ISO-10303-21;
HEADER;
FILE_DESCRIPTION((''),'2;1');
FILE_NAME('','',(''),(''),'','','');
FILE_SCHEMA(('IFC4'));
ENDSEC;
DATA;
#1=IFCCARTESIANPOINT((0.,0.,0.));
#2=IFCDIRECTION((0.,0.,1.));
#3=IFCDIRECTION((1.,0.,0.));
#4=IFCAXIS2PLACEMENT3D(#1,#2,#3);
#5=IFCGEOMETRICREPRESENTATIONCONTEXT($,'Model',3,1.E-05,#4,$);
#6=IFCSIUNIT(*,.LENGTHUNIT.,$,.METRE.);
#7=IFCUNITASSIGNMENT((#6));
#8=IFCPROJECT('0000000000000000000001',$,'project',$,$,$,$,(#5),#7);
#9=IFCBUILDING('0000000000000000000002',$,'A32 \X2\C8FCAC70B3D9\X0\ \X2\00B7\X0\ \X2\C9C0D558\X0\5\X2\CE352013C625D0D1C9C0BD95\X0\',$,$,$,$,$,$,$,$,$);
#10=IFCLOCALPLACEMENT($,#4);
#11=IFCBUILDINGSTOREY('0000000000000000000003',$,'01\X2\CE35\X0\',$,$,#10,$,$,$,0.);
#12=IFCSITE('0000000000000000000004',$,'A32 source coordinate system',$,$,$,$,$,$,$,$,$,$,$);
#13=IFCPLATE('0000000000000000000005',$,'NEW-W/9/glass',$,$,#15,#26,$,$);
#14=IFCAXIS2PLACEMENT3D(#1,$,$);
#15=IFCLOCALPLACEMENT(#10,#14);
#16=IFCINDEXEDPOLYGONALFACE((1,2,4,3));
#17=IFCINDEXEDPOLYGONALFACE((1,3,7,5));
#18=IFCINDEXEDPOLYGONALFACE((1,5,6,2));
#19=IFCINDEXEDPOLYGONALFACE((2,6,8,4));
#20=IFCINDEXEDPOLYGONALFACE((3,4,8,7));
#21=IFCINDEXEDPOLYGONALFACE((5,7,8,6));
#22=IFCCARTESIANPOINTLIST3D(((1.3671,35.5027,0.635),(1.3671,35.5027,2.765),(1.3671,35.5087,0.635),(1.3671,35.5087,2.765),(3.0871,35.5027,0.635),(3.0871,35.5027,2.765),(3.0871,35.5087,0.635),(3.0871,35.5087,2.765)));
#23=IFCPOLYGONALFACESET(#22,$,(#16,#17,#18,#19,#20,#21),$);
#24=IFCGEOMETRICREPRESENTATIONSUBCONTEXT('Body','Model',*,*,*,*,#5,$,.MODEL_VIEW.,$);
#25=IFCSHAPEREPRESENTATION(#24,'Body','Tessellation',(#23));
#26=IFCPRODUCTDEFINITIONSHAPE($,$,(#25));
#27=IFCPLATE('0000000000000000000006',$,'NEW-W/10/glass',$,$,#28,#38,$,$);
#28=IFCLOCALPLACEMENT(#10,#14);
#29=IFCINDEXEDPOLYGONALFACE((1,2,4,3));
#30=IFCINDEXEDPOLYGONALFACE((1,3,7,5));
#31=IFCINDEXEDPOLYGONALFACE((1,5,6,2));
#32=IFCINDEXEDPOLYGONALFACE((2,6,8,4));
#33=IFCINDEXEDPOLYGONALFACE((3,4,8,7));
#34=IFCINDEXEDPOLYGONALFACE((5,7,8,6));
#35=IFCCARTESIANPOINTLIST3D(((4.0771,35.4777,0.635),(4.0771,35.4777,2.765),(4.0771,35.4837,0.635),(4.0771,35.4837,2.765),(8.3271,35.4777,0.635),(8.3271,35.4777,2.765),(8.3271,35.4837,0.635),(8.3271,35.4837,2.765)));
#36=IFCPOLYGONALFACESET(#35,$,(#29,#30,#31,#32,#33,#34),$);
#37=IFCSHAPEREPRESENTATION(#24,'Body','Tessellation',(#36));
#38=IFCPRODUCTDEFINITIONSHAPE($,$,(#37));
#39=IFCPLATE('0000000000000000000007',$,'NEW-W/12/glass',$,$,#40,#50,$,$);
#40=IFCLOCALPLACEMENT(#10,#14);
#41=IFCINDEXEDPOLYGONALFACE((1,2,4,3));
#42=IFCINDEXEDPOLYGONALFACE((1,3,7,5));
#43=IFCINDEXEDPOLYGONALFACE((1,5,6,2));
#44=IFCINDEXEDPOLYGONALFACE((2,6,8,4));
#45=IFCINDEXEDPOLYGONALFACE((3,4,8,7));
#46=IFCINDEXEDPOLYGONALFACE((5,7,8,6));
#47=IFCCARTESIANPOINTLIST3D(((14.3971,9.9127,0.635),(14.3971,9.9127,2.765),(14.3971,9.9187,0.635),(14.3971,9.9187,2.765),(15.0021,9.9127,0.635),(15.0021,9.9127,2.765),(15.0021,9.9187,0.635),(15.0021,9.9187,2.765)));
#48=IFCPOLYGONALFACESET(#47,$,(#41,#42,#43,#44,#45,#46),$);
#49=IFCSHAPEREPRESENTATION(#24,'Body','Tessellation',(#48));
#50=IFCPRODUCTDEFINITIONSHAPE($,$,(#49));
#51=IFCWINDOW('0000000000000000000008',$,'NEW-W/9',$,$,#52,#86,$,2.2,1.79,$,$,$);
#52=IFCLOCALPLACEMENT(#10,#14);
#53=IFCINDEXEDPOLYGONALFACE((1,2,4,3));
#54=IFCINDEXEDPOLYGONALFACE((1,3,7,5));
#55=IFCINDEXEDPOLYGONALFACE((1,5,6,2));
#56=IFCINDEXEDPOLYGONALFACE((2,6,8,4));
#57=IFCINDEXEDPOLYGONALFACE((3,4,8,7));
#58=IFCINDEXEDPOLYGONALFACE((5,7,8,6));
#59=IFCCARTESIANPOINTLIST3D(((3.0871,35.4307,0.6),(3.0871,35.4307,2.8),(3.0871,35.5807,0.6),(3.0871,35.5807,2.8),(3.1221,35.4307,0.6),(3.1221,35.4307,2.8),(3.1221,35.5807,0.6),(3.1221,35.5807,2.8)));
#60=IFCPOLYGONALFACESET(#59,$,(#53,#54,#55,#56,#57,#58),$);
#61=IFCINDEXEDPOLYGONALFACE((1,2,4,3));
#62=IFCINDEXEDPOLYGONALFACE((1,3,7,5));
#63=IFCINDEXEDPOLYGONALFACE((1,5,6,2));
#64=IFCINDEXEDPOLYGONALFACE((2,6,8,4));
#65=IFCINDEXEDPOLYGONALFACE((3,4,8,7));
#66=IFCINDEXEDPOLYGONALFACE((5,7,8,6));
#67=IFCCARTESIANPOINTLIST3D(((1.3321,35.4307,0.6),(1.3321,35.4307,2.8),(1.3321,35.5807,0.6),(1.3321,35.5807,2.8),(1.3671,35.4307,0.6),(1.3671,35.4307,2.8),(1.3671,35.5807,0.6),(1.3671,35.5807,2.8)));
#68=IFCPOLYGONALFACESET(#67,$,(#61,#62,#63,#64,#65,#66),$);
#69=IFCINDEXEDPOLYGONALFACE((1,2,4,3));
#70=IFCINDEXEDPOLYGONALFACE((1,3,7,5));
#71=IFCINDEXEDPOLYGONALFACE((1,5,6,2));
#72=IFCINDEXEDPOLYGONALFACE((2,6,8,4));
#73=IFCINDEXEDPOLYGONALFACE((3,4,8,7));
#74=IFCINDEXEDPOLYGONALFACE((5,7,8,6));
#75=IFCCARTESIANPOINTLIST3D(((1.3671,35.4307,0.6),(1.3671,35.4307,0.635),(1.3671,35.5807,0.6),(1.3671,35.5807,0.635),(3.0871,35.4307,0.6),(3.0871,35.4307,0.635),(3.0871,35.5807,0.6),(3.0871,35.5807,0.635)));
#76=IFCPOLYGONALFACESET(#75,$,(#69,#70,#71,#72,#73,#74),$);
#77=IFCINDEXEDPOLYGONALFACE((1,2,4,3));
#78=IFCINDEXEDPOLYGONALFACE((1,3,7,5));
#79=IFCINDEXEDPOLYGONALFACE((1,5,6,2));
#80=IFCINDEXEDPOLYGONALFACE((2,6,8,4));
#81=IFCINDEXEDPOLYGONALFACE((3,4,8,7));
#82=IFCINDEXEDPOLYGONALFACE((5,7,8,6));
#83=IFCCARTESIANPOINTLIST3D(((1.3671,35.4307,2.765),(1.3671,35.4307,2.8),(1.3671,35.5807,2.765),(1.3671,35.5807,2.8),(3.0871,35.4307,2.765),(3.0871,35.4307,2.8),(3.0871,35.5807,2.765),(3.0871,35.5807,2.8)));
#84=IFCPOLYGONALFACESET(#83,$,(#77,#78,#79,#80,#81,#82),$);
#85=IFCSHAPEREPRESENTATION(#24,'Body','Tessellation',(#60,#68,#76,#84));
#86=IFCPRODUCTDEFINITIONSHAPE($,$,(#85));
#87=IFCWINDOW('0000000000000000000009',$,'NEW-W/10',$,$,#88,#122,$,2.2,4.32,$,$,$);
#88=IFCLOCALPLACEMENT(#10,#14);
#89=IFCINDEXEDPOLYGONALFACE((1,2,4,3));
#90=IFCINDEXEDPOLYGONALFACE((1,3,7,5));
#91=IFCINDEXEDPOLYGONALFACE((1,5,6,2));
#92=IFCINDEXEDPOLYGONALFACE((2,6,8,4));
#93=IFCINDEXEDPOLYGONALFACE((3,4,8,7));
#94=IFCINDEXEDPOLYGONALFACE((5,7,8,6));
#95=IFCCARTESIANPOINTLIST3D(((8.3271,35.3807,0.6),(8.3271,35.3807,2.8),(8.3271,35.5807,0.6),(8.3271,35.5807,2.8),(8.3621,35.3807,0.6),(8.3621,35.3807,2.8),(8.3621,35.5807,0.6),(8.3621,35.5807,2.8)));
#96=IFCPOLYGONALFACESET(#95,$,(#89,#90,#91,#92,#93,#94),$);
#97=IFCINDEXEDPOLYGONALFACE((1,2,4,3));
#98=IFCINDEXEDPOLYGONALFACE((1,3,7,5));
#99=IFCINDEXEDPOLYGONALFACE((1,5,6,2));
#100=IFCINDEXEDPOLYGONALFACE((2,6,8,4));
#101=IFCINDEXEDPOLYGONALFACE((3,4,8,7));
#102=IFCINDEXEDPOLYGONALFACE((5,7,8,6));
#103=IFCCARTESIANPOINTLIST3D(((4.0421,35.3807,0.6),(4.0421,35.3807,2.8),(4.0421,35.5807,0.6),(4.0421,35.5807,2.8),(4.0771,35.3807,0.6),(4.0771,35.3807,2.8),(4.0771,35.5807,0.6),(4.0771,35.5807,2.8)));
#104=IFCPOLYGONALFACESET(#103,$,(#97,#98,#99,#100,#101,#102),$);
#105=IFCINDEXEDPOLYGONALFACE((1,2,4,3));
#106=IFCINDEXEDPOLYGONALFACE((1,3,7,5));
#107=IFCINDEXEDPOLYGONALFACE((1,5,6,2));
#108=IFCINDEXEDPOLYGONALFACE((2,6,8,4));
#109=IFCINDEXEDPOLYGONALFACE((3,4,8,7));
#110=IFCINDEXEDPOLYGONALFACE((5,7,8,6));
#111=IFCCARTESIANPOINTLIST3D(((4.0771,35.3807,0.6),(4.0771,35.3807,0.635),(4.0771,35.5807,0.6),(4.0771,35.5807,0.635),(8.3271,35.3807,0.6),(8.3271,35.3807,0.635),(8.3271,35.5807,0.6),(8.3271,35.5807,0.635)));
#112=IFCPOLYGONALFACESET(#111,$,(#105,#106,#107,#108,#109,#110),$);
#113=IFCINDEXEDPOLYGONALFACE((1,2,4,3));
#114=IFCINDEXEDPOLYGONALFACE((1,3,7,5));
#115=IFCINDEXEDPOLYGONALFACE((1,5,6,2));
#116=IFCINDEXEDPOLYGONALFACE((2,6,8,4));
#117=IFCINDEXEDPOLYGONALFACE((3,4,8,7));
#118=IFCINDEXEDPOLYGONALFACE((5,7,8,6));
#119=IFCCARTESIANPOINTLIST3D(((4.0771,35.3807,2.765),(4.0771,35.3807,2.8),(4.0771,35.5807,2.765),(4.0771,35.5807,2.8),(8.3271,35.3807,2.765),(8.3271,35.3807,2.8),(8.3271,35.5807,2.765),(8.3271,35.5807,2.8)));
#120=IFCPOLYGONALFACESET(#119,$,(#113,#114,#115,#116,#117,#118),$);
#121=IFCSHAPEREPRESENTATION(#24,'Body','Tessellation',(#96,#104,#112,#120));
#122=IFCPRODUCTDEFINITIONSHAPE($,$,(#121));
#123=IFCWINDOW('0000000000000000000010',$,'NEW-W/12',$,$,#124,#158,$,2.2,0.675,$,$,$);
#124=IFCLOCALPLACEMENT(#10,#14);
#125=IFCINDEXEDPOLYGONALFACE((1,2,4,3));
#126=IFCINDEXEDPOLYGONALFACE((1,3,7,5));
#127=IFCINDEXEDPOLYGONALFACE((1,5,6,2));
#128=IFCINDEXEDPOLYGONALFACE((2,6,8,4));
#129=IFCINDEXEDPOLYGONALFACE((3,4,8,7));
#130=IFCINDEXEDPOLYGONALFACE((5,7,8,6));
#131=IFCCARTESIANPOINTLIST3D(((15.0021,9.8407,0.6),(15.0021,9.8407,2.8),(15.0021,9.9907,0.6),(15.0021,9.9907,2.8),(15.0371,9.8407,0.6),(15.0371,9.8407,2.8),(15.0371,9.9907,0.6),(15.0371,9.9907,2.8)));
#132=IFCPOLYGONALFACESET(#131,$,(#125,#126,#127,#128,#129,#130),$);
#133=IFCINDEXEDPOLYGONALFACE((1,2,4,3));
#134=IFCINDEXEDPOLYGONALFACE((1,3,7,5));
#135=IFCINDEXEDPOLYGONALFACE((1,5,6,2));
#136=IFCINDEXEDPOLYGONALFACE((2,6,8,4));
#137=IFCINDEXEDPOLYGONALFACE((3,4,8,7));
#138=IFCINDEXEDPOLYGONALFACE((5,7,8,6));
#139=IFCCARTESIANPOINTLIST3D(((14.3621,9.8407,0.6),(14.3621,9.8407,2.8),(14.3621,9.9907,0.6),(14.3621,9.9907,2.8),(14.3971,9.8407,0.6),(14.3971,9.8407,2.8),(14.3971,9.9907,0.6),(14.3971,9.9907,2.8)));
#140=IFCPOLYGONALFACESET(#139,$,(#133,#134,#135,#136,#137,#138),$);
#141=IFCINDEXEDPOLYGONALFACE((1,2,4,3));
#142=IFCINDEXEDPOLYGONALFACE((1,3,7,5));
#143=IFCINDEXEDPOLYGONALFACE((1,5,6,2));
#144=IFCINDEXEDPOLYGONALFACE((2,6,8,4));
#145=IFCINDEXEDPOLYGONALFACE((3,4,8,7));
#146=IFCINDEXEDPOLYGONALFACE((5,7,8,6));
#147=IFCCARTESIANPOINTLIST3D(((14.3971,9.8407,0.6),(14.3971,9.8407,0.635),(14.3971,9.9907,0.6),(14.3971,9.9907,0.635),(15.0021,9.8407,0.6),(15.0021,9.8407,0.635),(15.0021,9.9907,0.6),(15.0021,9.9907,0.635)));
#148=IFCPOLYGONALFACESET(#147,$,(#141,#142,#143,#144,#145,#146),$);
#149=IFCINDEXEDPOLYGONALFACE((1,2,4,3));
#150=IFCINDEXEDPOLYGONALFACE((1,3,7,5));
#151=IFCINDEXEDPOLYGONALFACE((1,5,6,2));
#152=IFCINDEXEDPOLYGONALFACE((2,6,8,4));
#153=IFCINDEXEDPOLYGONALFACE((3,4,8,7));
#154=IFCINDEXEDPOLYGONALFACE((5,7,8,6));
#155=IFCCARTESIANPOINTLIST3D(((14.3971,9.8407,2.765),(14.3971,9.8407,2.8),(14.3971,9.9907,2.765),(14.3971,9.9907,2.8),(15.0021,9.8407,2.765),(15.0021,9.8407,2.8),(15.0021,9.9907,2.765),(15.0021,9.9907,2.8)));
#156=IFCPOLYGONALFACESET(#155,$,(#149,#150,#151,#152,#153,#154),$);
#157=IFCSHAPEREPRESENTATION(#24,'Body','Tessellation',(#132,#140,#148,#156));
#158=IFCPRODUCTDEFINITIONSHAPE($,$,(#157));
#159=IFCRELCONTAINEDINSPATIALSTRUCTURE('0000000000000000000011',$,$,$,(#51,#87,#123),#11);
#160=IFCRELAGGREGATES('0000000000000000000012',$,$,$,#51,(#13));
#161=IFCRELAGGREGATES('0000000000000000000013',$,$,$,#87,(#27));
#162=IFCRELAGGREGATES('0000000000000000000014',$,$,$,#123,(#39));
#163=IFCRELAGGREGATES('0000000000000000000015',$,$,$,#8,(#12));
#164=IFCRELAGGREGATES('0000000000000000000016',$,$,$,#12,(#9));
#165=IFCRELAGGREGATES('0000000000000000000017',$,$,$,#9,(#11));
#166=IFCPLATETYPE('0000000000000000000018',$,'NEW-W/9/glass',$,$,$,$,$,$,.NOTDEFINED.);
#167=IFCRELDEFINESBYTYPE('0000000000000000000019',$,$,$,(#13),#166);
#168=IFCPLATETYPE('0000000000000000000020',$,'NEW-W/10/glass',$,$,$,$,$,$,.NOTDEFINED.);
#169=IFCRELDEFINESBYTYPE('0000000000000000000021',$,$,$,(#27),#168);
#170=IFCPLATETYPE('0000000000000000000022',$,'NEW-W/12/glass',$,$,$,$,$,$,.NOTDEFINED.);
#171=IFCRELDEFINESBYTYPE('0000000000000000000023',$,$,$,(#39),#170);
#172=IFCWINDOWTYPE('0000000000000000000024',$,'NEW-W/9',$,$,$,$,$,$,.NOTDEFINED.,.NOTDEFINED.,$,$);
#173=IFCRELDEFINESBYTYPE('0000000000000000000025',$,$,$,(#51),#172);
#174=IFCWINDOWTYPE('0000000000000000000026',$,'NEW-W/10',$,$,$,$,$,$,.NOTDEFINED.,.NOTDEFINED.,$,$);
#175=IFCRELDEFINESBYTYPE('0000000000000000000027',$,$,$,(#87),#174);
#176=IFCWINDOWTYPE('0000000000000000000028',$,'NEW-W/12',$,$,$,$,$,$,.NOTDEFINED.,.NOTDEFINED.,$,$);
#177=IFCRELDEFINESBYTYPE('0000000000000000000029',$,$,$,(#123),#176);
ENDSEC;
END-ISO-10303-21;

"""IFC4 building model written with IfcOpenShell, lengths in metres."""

from ifc_helpers import new_model, si_unit, frame, origin, origin_with_axes, place, context, subcontext, project, spatial, polyline, outline, extrude, source, transform, mapped, type_object, type_shapes, element, aggregate, save


model = new_model("IFC4")

# Units and contexts
model_context = context("Model", 3, precision=1e-05, world=origin_with_axes())
body_context = subcontext(model_context, "Body", "Model", "MODEL_VIEW")
ifc_project = project(units=[si_unit("LENGTHUNIT", "METRE")], contexts=[model_context])

# Plates
storey_placement = place(None, origin_with_axes())
plate_type_1 = type_object("IfcPlateType", Name="NEW-W/9/glass", PredefinedType="NOTDEFINED")
shared_shape_1 = source(origin(), body_context, "Body", "SweptSolid", [
    extrude(outline(polyline([(3.0871, 35.5027), (1.3671, 35.5027), (1.3671, 35.5087), (3.0871, 35.5087), (3.0871, 35.5027)])), frame((0.0, 0.0, 0.635)), (0.0, 0.0, 1.0), 2.13),
])
type_shapes(plate_type_1, [shared_shape_1])
window_1_placement = place(storey_placement, origin_with_axes())
plate_1_placement = place(window_1_placement, origin_with_axes())
plate_1 = element("IfcPlate", 1, at=plate_1_placement, type_object=plate_type_1, Name="NEW-W/9/glass", context=body_context, shape_type="MappedRepresentation", body=[
    mapped(shared_shape_1, transform((0.0, 0.0, 0.0), scale=1.0)),
])
plate_type_2 = type_object("IfcPlateType", Name="NEW-W/10/glass", PredefinedType="NOTDEFINED")
shared_shape_2 = source(origin(), body_context, "Body", "SweptSolid", [
    extrude(outline(polyline([(8.3271, 35.4777), (4.0771, 35.4777), (4.0771, 35.4837), (8.3271, 35.4837), (8.3271, 35.4777)])), frame((0.0, 0.0, 0.635)), (0.0, 0.0, 1.0), 2.13),
])
type_shapes(plate_type_2, [shared_shape_2])
window_2_placement = place(storey_placement, origin_with_axes())
plate_2_placement = place(window_2_placement, origin_with_axes())
plate_2 = element("IfcPlate", 2, at=plate_2_placement, type_object=plate_type_2, Name="NEW-W/10/glass", context=body_context, shape_type="MappedRepresentation", body=[
    mapped(shared_shape_2, transform((0.0, 0.0, 0.0), scale=1.0)),
])
plate_type_3 = type_object("IfcPlateType", Name="NEW-W/12/glass", PredefinedType="NOTDEFINED")
shared_shape_3 = source(origin(), body_context, "Body", "SweptSolid", [
    extrude(outline(polyline([(15.0021, 9.9127), (14.3971, 9.9127), (14.3971, 9.9187), (15.0021, 9.9187), (15.0021, 9.9127)])), frame((0.0, 0.0, 0.635)), (0.0, 0.0, 1.0), 2.13),
])
type_shapes(plate_type_3, [shared_shape_3])
window_3_placement = place(storey_placement, origin_with_axes())
plate_3_placement = place(window_3_placement, origin_with_axes())
plate_3 = element("IfcPlate", 3, at=plate_3_placement, type_object=plate_type_3, Name="NEW-W/12/glass", context=body_context, shape_type="MappedRepresentation", body=[
    mapped(shared_shape_3, transform((0.0, 0.0, 0.0), scale=1.0)),
])

# Site, building, storey
site = spatial("IfcSite", under=ifc_project, Name="A32 source coordinate system")
building = spatial("IfcBuilding", under=site, Name="A32 주거동 · 지하5층–옥탑지붕")
storey = spatial("IfcBuildingStorey", under=building, at=storey_placement, Name="01층", Elevation=0.0)

# Windows
window_type_1 = type_object("IfcWindowType", Name="NEW-W/9", PartitioningType="NOTDEFINED", PredefinedType="NOTDEFINED")
shared_shape_4 = source(origin(), body_context, "Body", "SweptSolid", [
    extrude(outline(polyline([(3.0871, 35.4307), (3.0871, 35.5807), (3.1221, 35.5807), (3.1221, 35.4307), (3.0871, 35.4307)])), frame((0.0, 0.0, 0.6)), (0.0, 0.0, 1.0), 2.2),
    extrude(outline(polyline([(1.3321, 35.4307), (1.3321, 35.5807), (1.3671, 35.5807), (1.3671, 35.4307), (1.3321, 35.4307)])), frame((0.0, 0.0, 0.6)), (0.0, 0.0, 1.0), 2.2),
    extrude(outline(polyline([(3.0871, 35.4307), (3.0871, 35.5807), (1.3671, 35.5807), (1.3671, 35.4307), (3.0871, 35.4307)])), frame((0.0, 0.0, 0.6)), (0.0, 0.0, 1.0), 0.035),
    extrude(outline(polyline([(3.0871, 35.4307), (3.0871, 35.5807), (1.3671, 35.5807), (1.3671, 35.4307), (3.0871, 35.4307)])), frame((0.0, 0.0, 2.765)), (0.0, 0.0, 1.0), 0.035),
])
type_shapes(window_type_1, [shared_shape_4])
window_1 = element("IfcWindow", 4, at=window_1_placement, inside=storey, type_object=window_type_1, Name="NEW-W/9", OverallHeight=2.2, OverallWidth=1.79, context=body_context, shape_type="MappedRepresentation", body=[
    mapped(shared_shape_4, transform((0.0, 0.0, 0.0), scale=1.0)),
])
aggregate(window_1, [plate_1])
window_type_2 = type_object("IfcWindowType", Name="NEW-W/10", PartitioningType="NOTDEFINED", PredefinedType="NOTDEFINED")
shared_shape_5 = source(origin(), body_context, "Body", "SweptSolid", [
    extrude(outline(polyline([(8.3271, 35.3807), (8.3271, 35.5807), (8.3621, 35.5807), (8.3621, 35.3807), (8.3271, 35.3807)])), frame((0.0, 0.0, 0.6)), (0.0, 0.0, 1.0), 2.2),
    extrude(outline(polyline([(4.0421, 35.3807), (4.0421, 35.5807), (4.0771, 35.5807), (4.0771, 35.3807), (4.0421, 35.3807)])), frame((0.0, 0.0, 0.6)), (0.0, 0.0, 1.0), 2.2),
    extrude(outline(polyline([(8.3271, 35.3807), (8.3271, 35.5807), (4.0771, 35.5807), (4.0771, 35.3807), (8.3271, 35.3807)])), frame((0.0, 0.0, 0.6)), (0.0, 0.0, 1.0), 0.035),
    extrude(outline(polyline([(8.3271, 35.3807), (8.3271, 35.5807), (4.0771, 35.5807), (4.0771, 35.3807), (8.3271, 35.3807)])), frame((0.0, 0.0, 2.765)), (0.0, 0.0, 1.0), 0.035),
])
type_shapes(window_type_2, [shared_shape_5])
window_2 = element("IfcWindow", 5, at=window_2_placement, inside=storey, type_object=window_type_2, Name="NEW-W/10", OverallHeight=2.2, OverallWidth=4.32, context=body_context, shape_type="MappedRepresentation", body=[
    mapped(shared_shape_5, transform((0.0, 0.0, 0.0), scale=1.0)),
])
aggregate(window_2, [plate_2])
window_type_3 = type_object("IfcWindowType", Name="NEW-W/12", PartitioningType="NOTDEFINED", PredefinedType="NOTDEFINED")
shared_shape_6 = source(origin(), body_context, "Body", "SweptSolid", [
    extrude(outline(polyline([(15.0021, 9.8407), (15.0021, 9.9907), (15.0371, 9.9907), (15.0371, 9.8407), (15.0021, 9.8407)])), frame((0.0, 0.0, 0.6)), (0.0, 0.0, 1.0), 2.2),
    extrude(outline(polyline([(14.3621, 9.8407), (14.3621, 9.9907), (14.3971, 9.9907), (14.3971, 9.8407), (14.3621, 9.8407)])), frame((0.0, 0.0, 0.6)), (0.0, 0.0, 1.0), 2.2),
    extrude(outline(polyline([(15.0021, 9.8407), (15.0021, 9.9907), (14.3971, 9.9907), (14.3971, 9.8407), (15.0021, 9.8407)])), frame((0.0, 0.0, 0.6)), (0.0, 0.0, 1.0), 0.035),
    extrude(outline(polyline([(15.0021, 9.8407), (15.0021, 9.9907), (14.3971, 9.9907), (14.3971, 9.8407), (15.0021, 9.8407)])), frame((0.0, 0.0, 2.765)), (0.0, 0.0, 1.0), 0.035),
])
type_shapes(window_type_3, [shared_shape_6])
window_3 = element("IfcWindow", 6, at=window_3_placement, inside=storey, type_object=window_type_3, Name="NEW-W/12", OverallHeight=2.2, OverallWidth=0.675, context=body_context, shape_type="MappedRepresentation", body=[
    mapped(shared_shape_6, transform((0.0, 0.0, 0.0), scale=1.0)),
])
aggregate(window_3, [plate_3])

save(model, "model.ifc")
